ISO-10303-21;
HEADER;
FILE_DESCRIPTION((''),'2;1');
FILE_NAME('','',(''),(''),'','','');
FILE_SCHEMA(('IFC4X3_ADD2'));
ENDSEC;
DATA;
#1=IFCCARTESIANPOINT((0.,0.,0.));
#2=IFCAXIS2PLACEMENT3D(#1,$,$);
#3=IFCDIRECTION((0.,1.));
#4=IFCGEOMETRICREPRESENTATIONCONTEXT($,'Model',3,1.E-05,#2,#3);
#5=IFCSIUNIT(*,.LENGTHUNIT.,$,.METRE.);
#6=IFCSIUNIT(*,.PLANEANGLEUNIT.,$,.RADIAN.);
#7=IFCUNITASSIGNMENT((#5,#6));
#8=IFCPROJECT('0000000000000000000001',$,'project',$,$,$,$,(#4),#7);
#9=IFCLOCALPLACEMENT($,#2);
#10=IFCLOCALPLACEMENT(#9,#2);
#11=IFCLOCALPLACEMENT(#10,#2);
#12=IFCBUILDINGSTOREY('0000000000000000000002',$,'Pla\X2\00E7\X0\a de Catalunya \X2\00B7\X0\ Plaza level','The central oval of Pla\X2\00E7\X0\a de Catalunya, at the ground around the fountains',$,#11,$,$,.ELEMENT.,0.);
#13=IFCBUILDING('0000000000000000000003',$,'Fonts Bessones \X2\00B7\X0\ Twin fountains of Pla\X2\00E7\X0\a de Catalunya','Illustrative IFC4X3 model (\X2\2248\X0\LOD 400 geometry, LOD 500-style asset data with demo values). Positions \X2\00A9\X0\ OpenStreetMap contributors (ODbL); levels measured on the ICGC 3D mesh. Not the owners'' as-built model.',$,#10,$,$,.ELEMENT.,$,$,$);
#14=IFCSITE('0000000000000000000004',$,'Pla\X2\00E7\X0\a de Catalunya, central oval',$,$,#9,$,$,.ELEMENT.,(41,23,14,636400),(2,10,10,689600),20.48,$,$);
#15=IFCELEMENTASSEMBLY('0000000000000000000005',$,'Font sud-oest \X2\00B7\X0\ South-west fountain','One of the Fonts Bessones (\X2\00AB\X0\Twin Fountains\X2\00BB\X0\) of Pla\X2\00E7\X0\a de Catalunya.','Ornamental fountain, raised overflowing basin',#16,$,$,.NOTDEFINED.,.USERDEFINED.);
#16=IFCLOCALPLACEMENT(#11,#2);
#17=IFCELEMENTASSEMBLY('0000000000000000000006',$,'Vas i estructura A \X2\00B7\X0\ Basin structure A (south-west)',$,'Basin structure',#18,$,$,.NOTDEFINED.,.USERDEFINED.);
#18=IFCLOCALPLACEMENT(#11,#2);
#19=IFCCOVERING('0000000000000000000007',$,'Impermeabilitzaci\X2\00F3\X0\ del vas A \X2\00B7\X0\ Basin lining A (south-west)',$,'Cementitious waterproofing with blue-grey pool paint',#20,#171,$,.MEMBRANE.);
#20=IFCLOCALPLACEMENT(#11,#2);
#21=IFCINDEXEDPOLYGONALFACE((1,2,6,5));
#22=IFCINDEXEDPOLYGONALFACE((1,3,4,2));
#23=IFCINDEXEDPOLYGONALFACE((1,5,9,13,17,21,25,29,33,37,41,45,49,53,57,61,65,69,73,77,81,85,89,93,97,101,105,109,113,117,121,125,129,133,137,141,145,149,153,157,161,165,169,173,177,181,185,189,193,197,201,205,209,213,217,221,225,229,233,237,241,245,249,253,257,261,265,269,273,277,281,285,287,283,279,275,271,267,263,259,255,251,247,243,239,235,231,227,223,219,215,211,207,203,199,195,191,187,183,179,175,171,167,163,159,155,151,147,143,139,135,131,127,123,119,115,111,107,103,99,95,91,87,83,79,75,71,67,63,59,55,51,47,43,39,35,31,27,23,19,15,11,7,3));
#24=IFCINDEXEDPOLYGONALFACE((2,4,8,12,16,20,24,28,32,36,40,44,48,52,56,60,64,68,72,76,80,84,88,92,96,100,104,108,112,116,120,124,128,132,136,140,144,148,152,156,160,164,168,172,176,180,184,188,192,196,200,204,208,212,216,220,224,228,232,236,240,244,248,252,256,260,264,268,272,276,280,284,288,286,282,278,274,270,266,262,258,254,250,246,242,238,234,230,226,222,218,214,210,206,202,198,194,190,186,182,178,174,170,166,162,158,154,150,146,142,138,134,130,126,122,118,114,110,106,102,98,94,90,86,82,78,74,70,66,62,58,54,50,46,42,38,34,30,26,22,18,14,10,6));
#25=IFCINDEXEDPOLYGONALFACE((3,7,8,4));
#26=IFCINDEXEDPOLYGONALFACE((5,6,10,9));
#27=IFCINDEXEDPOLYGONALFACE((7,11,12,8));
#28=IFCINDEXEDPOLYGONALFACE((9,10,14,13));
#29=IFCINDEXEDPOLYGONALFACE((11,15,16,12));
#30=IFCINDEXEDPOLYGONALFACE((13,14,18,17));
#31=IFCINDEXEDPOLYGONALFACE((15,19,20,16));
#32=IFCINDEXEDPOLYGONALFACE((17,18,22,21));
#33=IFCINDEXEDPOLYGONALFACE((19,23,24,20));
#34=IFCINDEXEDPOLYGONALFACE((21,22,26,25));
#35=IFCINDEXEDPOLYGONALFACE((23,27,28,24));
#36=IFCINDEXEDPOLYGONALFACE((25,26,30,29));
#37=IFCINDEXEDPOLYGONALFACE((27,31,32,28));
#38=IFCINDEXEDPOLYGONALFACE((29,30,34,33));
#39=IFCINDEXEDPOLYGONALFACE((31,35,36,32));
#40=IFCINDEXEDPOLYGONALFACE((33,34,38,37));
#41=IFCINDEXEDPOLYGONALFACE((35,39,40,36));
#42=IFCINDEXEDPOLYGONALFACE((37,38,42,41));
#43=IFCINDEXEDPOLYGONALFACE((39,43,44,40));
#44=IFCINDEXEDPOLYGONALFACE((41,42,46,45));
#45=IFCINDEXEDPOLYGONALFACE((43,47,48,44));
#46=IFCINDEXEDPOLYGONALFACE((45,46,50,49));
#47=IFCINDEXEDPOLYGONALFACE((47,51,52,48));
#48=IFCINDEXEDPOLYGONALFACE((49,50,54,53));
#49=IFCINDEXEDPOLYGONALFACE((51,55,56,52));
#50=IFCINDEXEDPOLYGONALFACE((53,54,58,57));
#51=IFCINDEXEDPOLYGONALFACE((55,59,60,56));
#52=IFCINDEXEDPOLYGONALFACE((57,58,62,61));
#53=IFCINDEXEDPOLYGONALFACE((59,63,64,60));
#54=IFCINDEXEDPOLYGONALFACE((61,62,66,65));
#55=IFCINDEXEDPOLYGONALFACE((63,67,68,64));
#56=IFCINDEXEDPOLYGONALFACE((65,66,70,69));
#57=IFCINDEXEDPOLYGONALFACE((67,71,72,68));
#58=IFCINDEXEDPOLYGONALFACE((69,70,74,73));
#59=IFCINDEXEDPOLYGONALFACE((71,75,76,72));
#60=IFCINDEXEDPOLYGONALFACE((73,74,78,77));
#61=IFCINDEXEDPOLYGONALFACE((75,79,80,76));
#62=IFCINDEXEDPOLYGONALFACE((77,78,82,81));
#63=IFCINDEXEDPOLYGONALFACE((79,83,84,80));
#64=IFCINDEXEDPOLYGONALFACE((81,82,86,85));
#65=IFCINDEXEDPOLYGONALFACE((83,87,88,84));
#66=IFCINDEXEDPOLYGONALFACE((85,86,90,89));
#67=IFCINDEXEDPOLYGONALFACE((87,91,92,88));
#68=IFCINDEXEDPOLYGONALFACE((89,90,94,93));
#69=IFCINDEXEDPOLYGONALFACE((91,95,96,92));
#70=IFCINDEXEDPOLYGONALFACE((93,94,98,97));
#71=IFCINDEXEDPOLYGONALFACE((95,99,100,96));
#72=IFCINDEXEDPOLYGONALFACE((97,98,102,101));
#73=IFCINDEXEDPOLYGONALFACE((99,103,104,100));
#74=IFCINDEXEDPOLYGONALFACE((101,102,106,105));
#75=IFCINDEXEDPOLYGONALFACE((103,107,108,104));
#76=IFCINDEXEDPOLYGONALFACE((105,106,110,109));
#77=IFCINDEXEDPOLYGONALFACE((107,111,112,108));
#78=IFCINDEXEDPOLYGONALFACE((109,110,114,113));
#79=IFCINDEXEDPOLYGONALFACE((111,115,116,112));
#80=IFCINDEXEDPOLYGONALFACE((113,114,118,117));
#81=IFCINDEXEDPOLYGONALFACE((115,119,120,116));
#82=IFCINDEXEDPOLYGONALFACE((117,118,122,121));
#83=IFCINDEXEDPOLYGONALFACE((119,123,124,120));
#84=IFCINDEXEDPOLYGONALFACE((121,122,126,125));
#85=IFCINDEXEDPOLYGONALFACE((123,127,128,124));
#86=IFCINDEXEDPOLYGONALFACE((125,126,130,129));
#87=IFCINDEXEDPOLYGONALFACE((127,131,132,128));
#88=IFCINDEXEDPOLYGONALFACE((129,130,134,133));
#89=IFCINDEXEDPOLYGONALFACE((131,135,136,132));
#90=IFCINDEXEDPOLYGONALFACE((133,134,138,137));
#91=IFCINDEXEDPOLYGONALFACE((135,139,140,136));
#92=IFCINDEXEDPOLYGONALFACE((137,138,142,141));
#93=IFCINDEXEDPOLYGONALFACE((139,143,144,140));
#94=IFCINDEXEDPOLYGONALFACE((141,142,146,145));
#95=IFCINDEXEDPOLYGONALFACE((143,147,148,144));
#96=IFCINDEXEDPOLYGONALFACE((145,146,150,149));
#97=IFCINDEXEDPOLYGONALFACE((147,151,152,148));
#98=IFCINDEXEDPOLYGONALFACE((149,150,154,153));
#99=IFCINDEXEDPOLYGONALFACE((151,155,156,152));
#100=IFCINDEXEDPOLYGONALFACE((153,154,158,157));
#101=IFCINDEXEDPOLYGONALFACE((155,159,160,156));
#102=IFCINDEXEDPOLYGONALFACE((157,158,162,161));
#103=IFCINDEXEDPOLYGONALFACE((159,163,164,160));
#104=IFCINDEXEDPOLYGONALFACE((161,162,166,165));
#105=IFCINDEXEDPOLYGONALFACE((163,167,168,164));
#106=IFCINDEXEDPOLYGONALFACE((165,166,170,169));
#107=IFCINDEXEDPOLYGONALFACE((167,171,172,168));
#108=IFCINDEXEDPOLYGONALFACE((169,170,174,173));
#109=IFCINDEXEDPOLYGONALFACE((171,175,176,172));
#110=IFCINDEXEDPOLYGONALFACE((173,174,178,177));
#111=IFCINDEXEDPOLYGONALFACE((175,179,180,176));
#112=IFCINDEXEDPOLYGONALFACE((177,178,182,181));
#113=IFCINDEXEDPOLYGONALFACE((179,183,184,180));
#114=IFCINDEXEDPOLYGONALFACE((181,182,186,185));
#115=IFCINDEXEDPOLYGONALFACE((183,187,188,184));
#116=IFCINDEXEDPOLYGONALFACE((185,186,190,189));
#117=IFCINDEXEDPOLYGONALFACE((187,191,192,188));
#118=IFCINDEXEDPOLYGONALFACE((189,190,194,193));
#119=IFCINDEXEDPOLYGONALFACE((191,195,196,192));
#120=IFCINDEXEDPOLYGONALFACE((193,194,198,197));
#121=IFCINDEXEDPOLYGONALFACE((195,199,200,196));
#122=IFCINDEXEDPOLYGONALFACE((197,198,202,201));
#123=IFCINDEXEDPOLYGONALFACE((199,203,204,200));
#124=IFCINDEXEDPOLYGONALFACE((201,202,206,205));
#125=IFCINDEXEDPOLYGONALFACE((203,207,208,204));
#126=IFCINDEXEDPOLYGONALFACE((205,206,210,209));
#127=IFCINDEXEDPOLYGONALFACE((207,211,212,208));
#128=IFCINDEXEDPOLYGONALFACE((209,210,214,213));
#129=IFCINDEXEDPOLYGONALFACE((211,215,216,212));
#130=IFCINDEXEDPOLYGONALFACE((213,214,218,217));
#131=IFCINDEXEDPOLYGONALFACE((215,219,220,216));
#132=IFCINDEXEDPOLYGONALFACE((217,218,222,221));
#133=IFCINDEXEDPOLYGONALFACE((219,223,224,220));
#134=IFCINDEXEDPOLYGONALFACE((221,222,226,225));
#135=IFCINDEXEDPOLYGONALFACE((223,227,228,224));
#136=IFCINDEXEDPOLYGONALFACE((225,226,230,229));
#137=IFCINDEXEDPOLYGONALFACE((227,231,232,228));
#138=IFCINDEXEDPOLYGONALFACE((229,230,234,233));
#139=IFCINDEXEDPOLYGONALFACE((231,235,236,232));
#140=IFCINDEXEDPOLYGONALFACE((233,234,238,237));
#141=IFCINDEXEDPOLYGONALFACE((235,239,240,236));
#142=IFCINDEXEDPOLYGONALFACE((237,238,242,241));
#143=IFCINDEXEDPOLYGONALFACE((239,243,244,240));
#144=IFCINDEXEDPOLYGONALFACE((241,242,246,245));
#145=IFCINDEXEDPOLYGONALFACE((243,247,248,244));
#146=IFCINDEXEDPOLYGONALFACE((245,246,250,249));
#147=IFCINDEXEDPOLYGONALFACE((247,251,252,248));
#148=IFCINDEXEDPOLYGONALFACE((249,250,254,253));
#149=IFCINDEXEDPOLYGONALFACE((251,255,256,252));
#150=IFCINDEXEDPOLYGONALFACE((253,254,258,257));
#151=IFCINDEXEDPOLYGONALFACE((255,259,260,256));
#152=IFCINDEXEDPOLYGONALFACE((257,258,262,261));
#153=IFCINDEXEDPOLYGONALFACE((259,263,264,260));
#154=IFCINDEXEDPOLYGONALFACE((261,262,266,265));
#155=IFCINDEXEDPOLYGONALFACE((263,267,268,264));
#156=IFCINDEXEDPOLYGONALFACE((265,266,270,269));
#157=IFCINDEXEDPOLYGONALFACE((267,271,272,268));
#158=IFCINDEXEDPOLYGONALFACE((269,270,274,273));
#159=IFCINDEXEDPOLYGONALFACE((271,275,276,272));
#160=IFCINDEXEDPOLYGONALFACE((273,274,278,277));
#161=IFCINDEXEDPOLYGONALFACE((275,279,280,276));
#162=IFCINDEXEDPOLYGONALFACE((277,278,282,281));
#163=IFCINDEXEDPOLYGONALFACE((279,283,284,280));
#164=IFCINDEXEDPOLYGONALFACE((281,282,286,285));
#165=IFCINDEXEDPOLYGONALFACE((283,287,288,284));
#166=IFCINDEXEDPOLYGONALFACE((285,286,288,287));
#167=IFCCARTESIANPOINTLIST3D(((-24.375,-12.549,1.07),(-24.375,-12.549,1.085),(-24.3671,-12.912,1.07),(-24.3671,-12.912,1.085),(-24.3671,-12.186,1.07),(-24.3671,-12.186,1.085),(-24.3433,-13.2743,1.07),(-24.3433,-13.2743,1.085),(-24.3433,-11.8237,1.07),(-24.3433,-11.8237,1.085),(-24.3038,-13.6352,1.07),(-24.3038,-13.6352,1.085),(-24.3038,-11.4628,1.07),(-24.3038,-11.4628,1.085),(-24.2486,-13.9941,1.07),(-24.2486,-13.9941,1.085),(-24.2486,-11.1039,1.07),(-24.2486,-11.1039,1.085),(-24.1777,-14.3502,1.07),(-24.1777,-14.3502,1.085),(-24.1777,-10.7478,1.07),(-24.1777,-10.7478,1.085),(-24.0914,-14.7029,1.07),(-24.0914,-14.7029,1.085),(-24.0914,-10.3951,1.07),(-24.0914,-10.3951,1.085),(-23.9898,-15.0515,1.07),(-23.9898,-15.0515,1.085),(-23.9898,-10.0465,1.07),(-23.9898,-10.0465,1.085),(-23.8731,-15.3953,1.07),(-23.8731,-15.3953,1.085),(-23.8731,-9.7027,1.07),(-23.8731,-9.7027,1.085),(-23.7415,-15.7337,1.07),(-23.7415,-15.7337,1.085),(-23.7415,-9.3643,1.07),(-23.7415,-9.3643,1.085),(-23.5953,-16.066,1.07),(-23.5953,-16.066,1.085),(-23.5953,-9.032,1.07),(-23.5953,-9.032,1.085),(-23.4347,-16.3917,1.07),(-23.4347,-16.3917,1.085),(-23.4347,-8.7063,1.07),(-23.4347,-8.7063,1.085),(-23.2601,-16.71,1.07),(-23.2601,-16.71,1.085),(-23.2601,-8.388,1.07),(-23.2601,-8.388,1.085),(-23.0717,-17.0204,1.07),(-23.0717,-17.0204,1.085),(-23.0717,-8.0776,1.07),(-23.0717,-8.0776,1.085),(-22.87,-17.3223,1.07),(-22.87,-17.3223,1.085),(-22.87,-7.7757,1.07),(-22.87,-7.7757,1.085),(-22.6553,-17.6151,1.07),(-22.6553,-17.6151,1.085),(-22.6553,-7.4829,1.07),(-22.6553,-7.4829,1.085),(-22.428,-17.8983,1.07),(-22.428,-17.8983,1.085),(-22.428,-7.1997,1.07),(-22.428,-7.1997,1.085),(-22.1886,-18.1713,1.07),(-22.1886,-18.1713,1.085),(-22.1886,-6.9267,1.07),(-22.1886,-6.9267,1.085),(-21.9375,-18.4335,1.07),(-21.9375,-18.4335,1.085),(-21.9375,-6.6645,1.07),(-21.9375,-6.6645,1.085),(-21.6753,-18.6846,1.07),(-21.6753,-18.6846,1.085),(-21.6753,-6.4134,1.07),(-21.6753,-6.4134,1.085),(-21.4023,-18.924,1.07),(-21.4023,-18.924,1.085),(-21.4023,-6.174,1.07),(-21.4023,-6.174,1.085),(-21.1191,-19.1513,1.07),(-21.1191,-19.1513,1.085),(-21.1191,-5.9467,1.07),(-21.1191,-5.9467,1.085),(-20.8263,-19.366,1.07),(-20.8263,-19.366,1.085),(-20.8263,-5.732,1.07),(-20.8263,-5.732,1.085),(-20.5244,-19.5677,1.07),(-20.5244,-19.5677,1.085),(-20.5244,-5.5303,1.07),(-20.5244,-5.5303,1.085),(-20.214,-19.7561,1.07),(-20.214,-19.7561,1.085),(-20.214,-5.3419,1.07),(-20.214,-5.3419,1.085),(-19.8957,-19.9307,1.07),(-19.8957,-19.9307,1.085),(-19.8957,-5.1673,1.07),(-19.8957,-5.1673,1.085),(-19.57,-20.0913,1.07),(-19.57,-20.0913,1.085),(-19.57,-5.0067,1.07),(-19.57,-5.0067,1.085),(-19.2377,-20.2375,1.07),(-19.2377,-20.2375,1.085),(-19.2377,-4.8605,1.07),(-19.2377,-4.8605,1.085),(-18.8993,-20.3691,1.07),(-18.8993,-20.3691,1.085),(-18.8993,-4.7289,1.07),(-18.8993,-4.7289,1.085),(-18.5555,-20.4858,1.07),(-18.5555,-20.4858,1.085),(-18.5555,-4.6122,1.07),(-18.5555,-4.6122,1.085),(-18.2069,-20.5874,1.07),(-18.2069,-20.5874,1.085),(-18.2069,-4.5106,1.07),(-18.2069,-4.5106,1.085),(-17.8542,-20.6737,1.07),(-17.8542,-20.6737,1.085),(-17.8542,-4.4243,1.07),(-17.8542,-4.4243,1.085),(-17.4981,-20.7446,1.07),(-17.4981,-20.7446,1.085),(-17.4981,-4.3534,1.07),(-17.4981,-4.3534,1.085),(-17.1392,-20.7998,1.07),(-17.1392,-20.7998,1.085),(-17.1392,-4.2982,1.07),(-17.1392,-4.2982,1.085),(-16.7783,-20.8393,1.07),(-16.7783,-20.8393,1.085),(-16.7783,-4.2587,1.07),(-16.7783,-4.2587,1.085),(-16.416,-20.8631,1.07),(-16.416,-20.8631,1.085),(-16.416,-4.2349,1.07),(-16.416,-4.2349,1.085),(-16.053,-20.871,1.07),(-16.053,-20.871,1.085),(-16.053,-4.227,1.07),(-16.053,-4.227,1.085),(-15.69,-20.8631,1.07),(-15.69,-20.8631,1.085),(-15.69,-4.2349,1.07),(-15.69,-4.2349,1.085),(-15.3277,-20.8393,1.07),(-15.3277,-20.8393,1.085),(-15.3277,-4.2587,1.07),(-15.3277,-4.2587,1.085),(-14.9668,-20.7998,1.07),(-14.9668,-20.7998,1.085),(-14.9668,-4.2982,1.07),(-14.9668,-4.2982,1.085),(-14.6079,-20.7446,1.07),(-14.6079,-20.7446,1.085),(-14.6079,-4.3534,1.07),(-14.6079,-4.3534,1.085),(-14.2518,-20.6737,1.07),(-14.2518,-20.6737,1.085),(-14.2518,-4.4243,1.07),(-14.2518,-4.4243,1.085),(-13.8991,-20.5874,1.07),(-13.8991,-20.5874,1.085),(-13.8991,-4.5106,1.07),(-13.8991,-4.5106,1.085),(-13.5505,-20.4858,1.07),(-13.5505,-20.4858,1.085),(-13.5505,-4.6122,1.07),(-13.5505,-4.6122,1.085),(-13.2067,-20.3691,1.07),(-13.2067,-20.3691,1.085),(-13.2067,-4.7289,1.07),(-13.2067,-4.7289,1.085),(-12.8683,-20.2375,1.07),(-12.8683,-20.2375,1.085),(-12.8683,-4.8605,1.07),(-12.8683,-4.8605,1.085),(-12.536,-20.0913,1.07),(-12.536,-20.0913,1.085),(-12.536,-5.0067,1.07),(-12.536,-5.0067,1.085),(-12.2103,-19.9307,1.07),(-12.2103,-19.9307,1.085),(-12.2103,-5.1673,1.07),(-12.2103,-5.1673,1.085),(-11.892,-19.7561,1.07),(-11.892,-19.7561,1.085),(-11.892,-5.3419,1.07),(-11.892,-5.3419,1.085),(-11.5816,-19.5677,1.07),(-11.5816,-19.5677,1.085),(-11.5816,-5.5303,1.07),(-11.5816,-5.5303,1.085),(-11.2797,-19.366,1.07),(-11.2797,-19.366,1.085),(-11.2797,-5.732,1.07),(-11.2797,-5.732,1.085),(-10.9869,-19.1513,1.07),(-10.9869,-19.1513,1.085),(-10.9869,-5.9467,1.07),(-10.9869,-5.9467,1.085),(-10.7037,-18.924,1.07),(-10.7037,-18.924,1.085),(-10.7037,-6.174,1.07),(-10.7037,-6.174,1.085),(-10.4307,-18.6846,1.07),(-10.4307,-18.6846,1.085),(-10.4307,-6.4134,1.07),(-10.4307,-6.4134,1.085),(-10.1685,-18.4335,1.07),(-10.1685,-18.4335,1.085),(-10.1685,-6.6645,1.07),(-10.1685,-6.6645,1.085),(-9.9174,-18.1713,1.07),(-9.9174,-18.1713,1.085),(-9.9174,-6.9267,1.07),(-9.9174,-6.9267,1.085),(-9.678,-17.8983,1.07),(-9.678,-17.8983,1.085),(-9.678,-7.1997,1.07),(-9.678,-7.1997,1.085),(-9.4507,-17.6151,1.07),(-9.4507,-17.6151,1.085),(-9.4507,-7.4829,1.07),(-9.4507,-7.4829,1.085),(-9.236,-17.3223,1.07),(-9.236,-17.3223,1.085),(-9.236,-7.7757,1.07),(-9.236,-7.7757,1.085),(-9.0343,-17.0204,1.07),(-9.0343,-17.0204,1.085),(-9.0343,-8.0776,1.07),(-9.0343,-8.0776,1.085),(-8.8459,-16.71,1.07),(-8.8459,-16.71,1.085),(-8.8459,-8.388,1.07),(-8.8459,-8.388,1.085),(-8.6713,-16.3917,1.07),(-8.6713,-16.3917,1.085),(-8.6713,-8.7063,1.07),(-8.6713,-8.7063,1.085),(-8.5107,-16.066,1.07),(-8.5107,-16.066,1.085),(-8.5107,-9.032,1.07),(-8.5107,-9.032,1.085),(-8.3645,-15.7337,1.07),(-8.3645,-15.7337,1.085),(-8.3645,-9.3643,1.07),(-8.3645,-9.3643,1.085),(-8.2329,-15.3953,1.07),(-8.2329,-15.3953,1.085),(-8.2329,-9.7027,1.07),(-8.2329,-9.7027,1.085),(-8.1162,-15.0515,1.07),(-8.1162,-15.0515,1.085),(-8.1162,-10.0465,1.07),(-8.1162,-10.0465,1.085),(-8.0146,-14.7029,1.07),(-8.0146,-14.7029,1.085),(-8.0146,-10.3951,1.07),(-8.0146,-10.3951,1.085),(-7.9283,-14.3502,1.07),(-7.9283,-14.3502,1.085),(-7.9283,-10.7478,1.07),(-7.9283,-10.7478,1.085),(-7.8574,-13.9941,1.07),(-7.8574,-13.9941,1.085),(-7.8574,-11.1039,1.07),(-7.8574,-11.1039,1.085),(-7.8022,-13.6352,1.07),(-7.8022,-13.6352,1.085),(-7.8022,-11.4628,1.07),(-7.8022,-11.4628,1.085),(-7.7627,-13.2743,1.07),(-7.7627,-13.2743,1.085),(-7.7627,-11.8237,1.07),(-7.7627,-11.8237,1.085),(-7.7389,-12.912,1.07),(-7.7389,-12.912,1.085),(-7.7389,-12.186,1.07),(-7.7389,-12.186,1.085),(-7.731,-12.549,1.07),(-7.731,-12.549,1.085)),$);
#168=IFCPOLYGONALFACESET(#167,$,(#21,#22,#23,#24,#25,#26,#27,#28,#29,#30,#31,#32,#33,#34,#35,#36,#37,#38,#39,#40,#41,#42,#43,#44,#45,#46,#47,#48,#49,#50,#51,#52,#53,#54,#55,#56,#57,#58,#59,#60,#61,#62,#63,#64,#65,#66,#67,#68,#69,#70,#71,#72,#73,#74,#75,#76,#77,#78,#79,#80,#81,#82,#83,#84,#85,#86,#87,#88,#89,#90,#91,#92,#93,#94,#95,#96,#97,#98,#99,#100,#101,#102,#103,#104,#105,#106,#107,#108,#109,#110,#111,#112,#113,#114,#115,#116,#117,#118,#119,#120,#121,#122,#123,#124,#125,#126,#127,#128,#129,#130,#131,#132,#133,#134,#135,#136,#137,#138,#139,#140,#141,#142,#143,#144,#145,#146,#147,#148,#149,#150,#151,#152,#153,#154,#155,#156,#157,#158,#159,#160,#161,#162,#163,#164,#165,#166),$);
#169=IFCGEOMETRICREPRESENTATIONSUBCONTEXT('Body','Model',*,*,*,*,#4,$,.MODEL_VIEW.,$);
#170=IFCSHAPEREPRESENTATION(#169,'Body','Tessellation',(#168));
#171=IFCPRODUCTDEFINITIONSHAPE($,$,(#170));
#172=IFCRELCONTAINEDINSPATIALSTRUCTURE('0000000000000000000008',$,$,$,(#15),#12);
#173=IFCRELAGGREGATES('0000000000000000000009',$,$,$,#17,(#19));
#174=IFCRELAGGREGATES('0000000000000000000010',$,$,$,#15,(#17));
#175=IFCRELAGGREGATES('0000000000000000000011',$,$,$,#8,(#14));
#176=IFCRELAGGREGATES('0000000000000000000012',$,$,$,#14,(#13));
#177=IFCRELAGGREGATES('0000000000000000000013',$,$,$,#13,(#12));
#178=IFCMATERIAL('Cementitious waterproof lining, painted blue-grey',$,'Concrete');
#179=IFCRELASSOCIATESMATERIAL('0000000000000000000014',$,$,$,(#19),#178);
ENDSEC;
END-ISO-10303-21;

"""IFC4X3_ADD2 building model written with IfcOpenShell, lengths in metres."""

from ifc_helpers import new_model, si_unit, direction, frame, origin, origin_2d_with_axis, place, context, subcontext, project, spatial, circle, extrude, material, element, aggregate, save


model = new_model("IFC4X3_ADD2")

# Units and contexts
model_context = context("Model", 3, precision=1e-05, world=origin(), true_north=direction((0.0, 1.0)))
body_context = subcontext(model_context, "Body", "Model", "MODEL_VIEW")
ifc_project = project(units=[si_unit("LENGTHUNIT", "METRE"), si_unit("PLANEANGLEUNIT", "RADIAN")], contexts=[model_context])

# Site, building, storey
site_placement = place(None, origin())
site = spatial("IfcSite", under=ifc_project, at=site_placement, Name="Plaça de Catalunya, central oval", CompositionType="ELEMENT", RefLatitude=(41, 23, 14, 636400), RefLongitude=(2, 10, 10, 689600), RefElevation=20.48)
building_placement = place(site_placement, origin())
building = spatial("IfcBuilding", under=site, at=building_placement, Name="Fonts Bessones · Twin fountains of Plaça de Catalunya", Description="Illustrative IFC4X3 model (≈LOD 400 geometry, LOD 500-style asset data with demo values). Positions © OpenStreetMap contributors (ODbL); levels measured on the ICGC 3D mesh. Not the owners' as-built model.", CompositionType="ELEMENT")
storey_placement = place(building_placement, origin())
storey = spatial("IfcBuildingStorey", under=building, at=storey_placement, Name="Plaça de Catalunya · Plaza level", Description="The central oval of Plaça de Catalunya, at the ground around the fountains", CompositionType="ELEMENT", Elevation=0.0)

# Element assemblies, covering
assembly_1_placement = place(building_placement, origin())
assembly_1 = element("IfcElementAssembly", 1, at=assembly_1_placement, inside=storey, Name="Font sud-oest · South-west fountain", Description="One of the Fonts Bessones («Twin Fountains») of Plaça de Catalunya.", ObjectType="Ornamental fountain, raised overflowing basin", AssemblyPlace="NOTDEFINED", PredefinedType="USERDEFINED")
assembly_2_placement = place(building_placement, origin())
assembly_2 = element("IfcElementAssembly", 2, at=assembly_2_placement, Name="Vas i estructura A · Basin structure A (south-west)", ObjectType="Basin structure", AssemblyPlace="NOTDEFINED", PredefinedType="USERDEFINED")
ifc_material_1 = material(Name="Cementitious waterproof lining, painted blue-grey", Category="Concrete")
covering_1_placement = place(building_placement, origin())
covering_1 = element("IfcCovering", 3, at=covering_1_placement, material=ifc_material_1, Name="Impermeabilització del vas A · Basin lining A (south-west)", ObjectType="Cementitious waterproofing with blue-grey pool paint", PredefinedType="MEMBRANE", context=body_context, shape_type="SweptSolid", body=[
    extrude(circle(Radius=8.322, at=origin_2d_with_axis()), frame((-16.053, -12.549, 1.07)), (0.0, 0.0, 1.0), 0.015),
])
aggregate(assembly_2, [covering_1])
aggregate(assembly_1, [assembly_2])

save(model, "model.ifc")
